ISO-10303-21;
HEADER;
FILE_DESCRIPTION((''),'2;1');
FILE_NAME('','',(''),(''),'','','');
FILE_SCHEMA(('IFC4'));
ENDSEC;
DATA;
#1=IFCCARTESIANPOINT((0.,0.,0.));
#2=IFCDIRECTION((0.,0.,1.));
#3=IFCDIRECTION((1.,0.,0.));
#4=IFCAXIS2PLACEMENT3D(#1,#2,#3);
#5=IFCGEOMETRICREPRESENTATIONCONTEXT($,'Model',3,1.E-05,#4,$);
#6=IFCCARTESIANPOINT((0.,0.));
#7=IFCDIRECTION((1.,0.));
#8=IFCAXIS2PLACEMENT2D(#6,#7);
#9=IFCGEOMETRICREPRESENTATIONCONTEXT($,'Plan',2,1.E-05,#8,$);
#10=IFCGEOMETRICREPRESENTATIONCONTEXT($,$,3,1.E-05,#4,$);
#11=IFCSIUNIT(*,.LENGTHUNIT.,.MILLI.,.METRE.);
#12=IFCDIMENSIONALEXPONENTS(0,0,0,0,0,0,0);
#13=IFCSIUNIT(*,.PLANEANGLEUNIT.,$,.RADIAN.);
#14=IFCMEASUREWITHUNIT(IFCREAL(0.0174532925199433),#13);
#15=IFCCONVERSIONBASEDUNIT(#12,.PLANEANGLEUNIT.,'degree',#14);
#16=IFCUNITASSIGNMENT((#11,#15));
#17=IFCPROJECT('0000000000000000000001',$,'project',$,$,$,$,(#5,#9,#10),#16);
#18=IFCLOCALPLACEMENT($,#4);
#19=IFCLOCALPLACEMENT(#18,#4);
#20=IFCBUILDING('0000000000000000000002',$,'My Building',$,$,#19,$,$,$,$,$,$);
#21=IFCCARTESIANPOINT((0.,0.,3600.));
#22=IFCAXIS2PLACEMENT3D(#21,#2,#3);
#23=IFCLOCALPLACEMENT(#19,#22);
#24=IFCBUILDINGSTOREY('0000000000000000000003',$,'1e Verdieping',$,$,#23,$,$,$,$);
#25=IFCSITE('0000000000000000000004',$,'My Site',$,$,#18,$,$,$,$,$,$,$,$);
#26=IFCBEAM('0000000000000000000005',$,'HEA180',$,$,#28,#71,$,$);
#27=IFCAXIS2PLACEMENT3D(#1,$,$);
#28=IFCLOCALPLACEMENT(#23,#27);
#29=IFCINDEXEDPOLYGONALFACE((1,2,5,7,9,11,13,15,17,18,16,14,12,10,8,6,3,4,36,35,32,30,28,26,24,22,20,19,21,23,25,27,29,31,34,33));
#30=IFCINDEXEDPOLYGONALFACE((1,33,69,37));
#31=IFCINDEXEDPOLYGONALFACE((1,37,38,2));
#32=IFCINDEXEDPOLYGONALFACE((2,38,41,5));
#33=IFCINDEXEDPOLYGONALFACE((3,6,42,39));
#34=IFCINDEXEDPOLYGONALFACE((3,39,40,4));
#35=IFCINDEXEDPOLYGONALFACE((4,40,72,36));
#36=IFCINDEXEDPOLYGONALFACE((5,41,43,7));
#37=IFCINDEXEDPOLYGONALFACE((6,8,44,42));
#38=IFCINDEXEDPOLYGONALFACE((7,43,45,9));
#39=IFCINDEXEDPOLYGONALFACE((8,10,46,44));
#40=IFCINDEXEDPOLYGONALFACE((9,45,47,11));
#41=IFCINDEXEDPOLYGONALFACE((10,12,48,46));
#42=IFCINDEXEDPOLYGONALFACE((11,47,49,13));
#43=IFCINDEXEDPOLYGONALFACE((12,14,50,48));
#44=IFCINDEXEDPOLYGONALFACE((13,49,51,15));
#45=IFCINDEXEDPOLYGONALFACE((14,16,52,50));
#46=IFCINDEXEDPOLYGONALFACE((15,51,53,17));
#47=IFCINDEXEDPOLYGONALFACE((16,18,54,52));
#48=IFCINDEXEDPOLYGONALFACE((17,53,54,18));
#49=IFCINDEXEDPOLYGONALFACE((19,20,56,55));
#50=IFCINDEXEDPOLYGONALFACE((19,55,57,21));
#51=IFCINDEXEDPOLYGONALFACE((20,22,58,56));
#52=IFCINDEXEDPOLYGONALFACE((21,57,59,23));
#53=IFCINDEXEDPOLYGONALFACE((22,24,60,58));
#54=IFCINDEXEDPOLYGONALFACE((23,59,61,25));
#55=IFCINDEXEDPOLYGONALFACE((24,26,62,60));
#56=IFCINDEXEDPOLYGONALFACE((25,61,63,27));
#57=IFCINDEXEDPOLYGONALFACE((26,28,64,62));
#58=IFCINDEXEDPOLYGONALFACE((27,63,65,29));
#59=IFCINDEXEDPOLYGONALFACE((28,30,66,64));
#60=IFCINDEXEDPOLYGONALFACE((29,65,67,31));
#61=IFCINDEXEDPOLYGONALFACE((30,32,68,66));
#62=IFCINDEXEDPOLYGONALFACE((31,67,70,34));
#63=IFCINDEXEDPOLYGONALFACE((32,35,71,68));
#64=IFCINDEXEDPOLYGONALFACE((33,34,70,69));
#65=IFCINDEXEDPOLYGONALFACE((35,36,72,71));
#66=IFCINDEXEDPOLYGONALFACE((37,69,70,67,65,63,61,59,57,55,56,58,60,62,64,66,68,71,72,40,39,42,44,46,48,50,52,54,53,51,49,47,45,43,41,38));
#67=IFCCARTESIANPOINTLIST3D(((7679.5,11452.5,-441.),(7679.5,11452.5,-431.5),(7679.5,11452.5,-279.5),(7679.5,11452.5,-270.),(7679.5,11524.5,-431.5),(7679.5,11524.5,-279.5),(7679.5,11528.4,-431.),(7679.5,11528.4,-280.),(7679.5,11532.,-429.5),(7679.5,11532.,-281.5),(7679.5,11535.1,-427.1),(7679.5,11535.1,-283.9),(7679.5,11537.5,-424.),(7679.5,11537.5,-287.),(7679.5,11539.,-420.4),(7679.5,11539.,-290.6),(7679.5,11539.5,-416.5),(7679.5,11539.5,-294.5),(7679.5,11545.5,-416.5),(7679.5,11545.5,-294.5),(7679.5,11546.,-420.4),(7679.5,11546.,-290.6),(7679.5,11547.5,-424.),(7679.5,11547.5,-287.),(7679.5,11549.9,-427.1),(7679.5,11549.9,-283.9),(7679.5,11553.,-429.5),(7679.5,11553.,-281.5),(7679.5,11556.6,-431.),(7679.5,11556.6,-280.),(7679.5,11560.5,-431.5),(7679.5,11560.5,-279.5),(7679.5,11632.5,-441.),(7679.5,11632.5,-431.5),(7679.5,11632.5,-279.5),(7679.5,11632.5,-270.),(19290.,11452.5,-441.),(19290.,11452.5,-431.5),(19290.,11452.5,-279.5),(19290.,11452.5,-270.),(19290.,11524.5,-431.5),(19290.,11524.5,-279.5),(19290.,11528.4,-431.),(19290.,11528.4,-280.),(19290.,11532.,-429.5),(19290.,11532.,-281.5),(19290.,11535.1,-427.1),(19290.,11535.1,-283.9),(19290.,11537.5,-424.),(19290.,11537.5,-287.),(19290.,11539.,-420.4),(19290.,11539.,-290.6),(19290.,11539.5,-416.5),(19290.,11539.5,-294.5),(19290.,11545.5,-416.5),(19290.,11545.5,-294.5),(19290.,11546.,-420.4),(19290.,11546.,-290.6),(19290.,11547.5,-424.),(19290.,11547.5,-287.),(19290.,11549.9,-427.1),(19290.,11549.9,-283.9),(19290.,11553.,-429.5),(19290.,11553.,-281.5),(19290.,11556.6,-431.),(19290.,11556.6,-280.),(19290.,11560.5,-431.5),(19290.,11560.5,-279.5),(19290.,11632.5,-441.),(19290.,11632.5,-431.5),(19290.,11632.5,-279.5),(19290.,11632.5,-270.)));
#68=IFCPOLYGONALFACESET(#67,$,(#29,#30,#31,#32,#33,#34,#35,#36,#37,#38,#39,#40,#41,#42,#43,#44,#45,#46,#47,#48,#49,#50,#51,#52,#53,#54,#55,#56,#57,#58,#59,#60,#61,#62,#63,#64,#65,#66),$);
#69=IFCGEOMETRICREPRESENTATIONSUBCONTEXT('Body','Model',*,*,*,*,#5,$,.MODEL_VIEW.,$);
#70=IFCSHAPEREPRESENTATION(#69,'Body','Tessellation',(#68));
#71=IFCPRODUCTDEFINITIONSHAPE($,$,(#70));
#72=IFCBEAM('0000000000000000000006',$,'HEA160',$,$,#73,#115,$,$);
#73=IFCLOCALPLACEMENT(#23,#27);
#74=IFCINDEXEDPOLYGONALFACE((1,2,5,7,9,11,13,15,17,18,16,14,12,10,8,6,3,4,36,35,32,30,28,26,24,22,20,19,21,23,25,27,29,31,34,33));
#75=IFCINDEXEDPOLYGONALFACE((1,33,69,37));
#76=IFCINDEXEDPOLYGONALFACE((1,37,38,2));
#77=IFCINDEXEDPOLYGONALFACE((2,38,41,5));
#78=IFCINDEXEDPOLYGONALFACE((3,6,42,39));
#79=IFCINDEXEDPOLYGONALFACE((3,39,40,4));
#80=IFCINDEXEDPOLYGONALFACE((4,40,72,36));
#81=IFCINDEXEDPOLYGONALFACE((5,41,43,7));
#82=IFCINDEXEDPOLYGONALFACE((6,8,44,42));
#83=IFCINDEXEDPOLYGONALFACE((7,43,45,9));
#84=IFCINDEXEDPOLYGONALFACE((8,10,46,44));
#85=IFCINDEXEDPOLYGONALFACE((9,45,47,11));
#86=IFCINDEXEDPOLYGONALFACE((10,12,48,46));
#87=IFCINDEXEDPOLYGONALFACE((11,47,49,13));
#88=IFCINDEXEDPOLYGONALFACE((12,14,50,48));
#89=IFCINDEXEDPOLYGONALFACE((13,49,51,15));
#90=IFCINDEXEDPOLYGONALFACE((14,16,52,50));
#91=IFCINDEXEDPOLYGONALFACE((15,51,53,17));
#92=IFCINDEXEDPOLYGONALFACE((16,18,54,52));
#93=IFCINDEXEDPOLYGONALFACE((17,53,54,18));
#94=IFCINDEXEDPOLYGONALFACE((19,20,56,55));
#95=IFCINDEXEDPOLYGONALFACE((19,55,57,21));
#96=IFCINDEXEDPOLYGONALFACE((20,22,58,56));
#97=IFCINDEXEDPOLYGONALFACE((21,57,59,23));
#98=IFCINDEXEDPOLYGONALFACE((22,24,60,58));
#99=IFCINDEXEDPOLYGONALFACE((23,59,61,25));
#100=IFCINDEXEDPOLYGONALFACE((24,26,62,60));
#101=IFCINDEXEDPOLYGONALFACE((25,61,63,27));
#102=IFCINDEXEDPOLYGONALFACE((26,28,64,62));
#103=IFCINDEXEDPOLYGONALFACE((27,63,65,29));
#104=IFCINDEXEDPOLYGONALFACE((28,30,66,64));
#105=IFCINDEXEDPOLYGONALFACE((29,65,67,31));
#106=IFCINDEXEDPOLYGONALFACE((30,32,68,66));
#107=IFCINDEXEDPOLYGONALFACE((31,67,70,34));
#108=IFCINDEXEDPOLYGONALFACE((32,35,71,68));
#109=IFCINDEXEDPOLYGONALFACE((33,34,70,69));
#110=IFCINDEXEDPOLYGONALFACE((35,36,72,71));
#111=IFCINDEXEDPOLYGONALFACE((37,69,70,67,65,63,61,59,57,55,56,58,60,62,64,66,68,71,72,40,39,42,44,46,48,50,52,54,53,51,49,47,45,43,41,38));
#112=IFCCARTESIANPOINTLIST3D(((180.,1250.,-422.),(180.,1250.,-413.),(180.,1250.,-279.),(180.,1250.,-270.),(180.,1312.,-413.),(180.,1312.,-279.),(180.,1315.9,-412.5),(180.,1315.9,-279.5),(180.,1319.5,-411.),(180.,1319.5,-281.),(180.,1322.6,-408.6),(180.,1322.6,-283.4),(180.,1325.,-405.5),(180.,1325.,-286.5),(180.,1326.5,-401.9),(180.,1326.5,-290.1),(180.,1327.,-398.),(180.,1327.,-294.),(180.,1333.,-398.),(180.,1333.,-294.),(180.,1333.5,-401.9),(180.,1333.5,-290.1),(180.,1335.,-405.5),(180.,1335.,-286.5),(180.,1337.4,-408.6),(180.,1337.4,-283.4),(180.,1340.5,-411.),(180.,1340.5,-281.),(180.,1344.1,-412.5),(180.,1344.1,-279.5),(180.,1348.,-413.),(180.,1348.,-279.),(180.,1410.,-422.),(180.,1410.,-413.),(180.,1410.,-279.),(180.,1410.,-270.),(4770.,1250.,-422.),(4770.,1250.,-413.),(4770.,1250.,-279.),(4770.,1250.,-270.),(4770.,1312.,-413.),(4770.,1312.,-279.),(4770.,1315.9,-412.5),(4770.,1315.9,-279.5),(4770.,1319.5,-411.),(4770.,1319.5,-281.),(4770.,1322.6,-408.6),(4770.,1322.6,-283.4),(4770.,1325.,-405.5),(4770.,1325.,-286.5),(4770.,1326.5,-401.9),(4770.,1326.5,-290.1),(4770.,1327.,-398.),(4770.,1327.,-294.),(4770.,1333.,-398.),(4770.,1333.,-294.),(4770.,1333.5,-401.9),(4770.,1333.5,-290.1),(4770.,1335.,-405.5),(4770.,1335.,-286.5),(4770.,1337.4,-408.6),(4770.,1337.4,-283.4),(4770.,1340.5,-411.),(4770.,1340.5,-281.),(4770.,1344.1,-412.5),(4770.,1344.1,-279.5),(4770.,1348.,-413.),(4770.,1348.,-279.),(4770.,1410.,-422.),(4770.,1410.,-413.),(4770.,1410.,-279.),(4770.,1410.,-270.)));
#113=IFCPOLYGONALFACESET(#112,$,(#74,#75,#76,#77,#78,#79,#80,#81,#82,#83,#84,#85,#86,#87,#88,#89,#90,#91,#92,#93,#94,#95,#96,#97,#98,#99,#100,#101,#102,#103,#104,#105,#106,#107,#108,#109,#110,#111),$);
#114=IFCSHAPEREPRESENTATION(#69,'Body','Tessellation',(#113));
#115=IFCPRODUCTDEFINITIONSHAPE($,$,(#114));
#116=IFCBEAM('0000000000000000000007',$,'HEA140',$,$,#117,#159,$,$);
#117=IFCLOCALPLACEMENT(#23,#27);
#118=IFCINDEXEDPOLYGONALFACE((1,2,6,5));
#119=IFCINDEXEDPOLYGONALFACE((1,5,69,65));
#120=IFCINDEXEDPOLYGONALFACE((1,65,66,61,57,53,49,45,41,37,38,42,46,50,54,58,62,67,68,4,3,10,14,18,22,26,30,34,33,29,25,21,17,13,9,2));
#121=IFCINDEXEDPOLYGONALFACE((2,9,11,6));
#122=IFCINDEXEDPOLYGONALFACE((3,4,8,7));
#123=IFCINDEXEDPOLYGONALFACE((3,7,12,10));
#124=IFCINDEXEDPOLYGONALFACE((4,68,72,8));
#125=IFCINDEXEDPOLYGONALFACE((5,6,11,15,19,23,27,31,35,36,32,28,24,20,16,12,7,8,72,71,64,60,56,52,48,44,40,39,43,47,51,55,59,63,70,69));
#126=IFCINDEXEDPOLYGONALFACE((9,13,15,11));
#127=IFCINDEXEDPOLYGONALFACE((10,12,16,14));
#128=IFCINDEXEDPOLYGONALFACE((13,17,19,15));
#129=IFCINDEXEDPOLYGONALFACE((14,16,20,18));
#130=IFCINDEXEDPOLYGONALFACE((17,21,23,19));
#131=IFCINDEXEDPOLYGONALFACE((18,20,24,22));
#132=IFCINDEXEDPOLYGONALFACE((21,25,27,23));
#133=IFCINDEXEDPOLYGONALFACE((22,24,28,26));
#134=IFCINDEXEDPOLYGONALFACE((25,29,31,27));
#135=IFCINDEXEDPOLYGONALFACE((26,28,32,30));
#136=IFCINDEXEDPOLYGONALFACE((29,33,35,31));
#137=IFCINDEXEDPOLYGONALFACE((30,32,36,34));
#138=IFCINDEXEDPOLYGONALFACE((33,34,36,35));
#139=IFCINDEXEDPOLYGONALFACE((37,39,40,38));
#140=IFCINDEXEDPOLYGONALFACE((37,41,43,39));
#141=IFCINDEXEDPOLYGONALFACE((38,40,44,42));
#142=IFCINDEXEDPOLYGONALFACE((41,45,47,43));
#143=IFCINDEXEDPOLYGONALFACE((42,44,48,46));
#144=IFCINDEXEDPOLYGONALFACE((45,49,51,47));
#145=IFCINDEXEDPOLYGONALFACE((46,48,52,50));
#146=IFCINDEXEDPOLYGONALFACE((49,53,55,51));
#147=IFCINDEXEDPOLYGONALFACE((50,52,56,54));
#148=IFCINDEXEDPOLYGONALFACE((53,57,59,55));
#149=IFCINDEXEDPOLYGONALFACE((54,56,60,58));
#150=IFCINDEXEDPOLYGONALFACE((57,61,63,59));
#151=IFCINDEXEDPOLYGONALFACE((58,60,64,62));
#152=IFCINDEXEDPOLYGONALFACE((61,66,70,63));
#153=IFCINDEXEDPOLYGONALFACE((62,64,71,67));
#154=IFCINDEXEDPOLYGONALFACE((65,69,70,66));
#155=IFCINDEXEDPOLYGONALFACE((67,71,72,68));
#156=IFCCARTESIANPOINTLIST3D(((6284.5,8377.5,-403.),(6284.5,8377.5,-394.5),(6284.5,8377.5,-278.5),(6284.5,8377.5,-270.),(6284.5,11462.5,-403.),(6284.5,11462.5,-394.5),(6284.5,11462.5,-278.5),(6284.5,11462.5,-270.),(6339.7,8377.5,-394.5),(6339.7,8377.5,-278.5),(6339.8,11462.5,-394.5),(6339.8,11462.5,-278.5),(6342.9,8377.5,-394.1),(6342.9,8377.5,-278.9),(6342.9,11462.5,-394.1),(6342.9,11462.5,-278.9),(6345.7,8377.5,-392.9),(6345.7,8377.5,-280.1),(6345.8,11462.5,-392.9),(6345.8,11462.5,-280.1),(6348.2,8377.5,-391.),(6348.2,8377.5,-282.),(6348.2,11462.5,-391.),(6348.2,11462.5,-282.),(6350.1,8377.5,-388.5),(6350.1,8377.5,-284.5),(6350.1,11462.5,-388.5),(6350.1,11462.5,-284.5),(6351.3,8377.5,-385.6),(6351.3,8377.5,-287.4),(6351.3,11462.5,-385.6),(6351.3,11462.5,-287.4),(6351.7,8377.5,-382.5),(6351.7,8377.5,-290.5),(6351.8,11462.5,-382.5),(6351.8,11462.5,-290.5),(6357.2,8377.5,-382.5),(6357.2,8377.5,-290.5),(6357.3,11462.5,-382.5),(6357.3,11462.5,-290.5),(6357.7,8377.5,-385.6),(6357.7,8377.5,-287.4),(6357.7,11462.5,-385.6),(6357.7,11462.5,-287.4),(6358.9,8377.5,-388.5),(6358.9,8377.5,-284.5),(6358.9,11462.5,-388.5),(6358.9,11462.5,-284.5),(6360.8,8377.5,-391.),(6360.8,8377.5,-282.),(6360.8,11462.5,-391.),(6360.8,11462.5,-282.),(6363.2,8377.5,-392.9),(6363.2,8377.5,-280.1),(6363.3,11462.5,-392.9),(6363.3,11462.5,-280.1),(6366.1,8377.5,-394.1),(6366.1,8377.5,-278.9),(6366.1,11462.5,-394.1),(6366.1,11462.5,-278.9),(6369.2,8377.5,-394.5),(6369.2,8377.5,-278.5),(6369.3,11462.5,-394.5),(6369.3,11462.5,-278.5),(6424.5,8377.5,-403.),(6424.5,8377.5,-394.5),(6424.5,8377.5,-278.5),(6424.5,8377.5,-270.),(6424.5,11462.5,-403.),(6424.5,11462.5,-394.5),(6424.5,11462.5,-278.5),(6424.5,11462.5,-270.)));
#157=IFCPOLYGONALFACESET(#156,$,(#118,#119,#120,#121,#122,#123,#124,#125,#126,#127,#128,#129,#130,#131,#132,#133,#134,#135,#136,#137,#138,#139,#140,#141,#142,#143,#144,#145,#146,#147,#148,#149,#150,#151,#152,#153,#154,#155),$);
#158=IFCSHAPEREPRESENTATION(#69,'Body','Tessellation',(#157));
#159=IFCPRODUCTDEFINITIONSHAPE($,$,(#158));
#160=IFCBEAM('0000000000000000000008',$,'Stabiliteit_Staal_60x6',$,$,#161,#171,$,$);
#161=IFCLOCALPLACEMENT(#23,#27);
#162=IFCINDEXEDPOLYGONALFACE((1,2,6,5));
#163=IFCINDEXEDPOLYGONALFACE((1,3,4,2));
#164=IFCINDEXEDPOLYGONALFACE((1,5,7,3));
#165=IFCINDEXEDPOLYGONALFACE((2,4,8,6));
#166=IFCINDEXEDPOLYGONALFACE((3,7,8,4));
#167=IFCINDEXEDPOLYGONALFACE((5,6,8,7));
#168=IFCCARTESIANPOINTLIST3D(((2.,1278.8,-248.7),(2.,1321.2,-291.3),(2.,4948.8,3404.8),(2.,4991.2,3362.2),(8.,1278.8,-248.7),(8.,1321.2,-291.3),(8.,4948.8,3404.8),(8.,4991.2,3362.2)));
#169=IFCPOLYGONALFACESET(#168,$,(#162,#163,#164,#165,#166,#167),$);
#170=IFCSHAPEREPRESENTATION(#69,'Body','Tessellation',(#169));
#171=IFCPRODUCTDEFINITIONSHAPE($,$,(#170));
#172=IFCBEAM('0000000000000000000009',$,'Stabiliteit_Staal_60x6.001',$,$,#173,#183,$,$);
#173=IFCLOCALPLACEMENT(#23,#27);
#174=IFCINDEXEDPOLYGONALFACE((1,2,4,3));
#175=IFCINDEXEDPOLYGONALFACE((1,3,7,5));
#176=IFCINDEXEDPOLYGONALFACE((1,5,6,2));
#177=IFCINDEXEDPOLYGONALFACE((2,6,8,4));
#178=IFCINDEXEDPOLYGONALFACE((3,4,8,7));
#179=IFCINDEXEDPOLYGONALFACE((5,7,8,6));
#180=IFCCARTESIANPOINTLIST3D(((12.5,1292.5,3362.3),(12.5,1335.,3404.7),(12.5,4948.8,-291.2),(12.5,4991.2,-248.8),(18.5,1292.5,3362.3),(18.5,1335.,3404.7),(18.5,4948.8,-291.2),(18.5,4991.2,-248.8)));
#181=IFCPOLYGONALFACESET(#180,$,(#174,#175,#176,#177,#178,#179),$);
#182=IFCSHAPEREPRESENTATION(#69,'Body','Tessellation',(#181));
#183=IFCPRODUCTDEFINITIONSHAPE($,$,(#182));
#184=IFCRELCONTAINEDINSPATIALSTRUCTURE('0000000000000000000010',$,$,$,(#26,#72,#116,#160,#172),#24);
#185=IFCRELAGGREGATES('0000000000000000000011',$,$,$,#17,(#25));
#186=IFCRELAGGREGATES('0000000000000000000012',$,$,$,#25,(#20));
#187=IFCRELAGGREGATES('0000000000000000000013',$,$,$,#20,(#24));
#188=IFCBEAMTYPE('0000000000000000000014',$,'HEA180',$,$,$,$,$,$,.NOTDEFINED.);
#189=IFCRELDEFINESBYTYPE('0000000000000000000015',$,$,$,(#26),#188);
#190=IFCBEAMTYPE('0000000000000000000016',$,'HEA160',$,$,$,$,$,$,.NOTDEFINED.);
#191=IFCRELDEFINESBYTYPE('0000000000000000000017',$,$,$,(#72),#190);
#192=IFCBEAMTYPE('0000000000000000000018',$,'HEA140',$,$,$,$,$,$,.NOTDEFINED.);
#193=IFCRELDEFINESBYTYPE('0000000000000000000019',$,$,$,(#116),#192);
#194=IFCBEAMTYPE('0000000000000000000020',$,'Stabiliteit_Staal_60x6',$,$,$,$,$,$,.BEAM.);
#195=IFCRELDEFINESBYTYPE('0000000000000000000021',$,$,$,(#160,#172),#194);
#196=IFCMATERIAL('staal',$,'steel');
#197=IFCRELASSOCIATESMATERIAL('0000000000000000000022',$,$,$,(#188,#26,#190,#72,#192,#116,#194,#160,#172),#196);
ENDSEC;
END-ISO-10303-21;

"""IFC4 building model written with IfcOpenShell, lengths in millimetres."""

from ifc_helpers import new_model, entity, si_unit, converted_unit, frame, origin_with_axes, origin_2d_with_axis, place, context, subcontext, project, spatial, rectangle, i_section, extrude, material, material_profile, profile_set, profile_usage, type_object, element, save


model = new_model("IFC4")

# Units and contexts
model_context = context("Model", 3, precision=1e-05, world=origin_with_axes())
plan_context = context("Plan", 2, precision=1e-05, world=origin_2d_with_axis())
context_of_model = context(None, 3, precision=1e-05, world=origin_with_axes())
body_context = subcontext(model_context, "Body", "Model", "MODEL_VIEW")
ifc_project = project(units=[si_unit("LENGTHUNIT", "METRE", prefix="MILLI"), converted_unit("PLANEANGLEUNIT", "degree", entity("IfcReal", 0.0174532925199433), si_unit("PLANEANGLEUNIT", "RADIAN"), dimensions=[0, 0, 0, 0, 0, 0, 0])], contexts=[model_context, plan_context, context_of_model])

# Site, building, storey
site_placement = place(None, origin_with_axes())
site = spatial("IfcSite", under=ifc_project, at=site_placement, Name="My Site")
building_placement = place(site_placement, origin_with_axes())
building = spatial("IfcBuilding", under=site, at=building_placement, Name="My Building")
storey_placement = place(building_placement, frame((0.0, 0.0, 3600.0), z_axis=(0.0, 0.0, 1.0), x_axis=(1.0, 0.0, 0.0)))
storey = spatial("IfcBuildingStorey", under=building, at=storey_placement, Name="1e Verdieping")

# Shared definitions
ifc_material = material(Name="staal", Category="steel")

# Beams
ifc_material_profile_1 = material_profile(ifc_material, i_section(OverallWidth=180.0, OverallDepth=171.0, WebThickness=6.0, FlangeThickness=9.5, FilletRadius=15.0))
ifc_profile_set_1 = profile_set([ifc_material_profile_1], Name="HEA180")
beam_type_1 = type_object("IfcBeamType", Name="HEA180", PredefinedType="NOTDEFINED", material=ifc_profile_set_1)
ifc_profile_usage_1 = profile_usage(ifc_profile_set_1)
beam_1_placement = place(storey_placement, frame((7679.5, 11542.5, -355.5), z_axis=(1.0, 0.0, 0.0), x_axis=(0.0, 1.0, 0.0)))
element("IfcBeam", 1, at=beam_1_placement, inside=storey, type_object=beam_type_1, material=ifc_profile_usage_1, Name="HEA180", context=body_context, shape_type="SweptSolid", body=[
    extrude(i_section(OverallWidth=180.0, OverallDepth=171.0, WebThickness=6.0, FlangeThickness=9.5, FilletRadius=15.0), origin_with_axes(), (0.0, 0.0, 1.0), 11610.5),
])
ifc_material_profile_2 = material_profile(ifc_material, i_section(OverallWidth=160.0, OverallDepth=152.0, WebThickness=6.0, FlangeThickness=9.0, FilletRadius=15.0))
ifc_profile_set_2 = profile_set([ifc_material_profile_2], Name="HEA160")
ifc_profile_usage_2 = profile_usage(ifc_profile_set_2, cardinal=5)
beam_type_2 = type_object("IfcBeamType", Name="HEA160", PredefinedType="NOTDEFINED", material=ifc_profile_set_2)
beam_2_placement = place(storey_placement, frame((180.0, 1330.0, -346.0), z_axis=(1.0, 0.0, 0.0), x_axis=(0.0, 1.0, 0.0)))
element("IfcBeam", 2, at=beam_2_placement, inside=storey, type_object=beam_type_2, material=ifc_profile_usage_2, Name="HEA160", context=body_context, shape_type="SweptSolid", body=[
    extrude(i_section(OverallWidth=160.0, OverallDepth=152.0, WebThickness=6.0, FlangeThickness=9.0, FilletRadius=15.0), origin_with_axes(), (0.0, 0.0, 1.0), 4590.0),
])
ifc_material_profile_3 = material_profile(ifc_material, i_section(OverallWidth=140.0, OverallDepth=133.0, WebThickness=5.5, FlangeThickness=8.5, FilletRadius=12.0))
ifc_profile_set_3 = profile_set([ifc_material_profile_3], Name="HEA140")
ifc_profile_usage_3 = profile_usage(ifc_profile_set_3)
beam_type_3 = type_object("IfcBeamType", Name="HEA140", PredefinedType="NOTDEFINED", material=ifc_profile_set_3)
beam_3_placement = place(storey_placement, frame((6354.5, 8377.5, -336.5), z_axis=(0.0, 1.0, 0.0), x_axis=(-1.0, 0.0, 0.0)))
element("IfcBeam", 3, at=beam_3_placement, inside=storey, type_object=beam_type_3, material=ifc_profile_usage_3, Name="HEA140", context=body_context, shape_type="SweptSolid", body=[
    extrude(i_section(OverallWidth=140.0, OverallDepth=133.0, WebThickness=5.5, FlangeThickness=8.5, FilletRadius=12.0), origin_with_axes(), (0.0, 0.0, 1.0), 3085.0),
])
ifc_material_profile_4 = material_profile(ifc_material, rectangle(XDim=6.0, YDim=60.0, kind="CURVE"))
ifc_profile_set_4 = profile_set([ifc_material_profile_4])
ifc_profile_usage_4 = profile_usage(ifc_profile_set_4)
beam_type_4 = type_object("IfcBeamType", Name="Stabiliteit_Staal_60x6", PredefinedType="BEAM", material=ifc_profile_set_4)
beam_4_placement = place(storey_placement, frame((5.0, 1300.0, -270.0), z_axis=(0.0, 0.708698, 0.705512), x_axis=(-1.0, 0.0, 0.0)))
element("IfcBeam", 4, at=beam_4_placement, inside=storey, type_object=beam_type_4, material=ifc_profile_usage_4, Name="Stabiliteit_Staal_60x6", context=body_context, shape_type="SweptSolid", body=[
    extrude(rectangle(XDim=6.0, YDim=60.0, kind="CURVE"), origin_with_axes(), (0.0, 0.0, 1.0), 5178.5),
])
ifc_profile_usage_5 = profile_usage(ifc_profile_set_4)
beam_5_placement = place(storey_placement, frame((15.5, 4970.0, -270.0), z_axis=(0.0, -0.707374, 0.70684), x_axis=(1.0, 0.0, 0.0)))
element("IfcBeam", 5, at=beam_5_placement, inside=storey, type_object=beam_type_4, material=ifc_profile_usage_5, Name="Stabiliteit_Staal_60x6.001", context=body_context, shape_type="SweptSolid", body=[
    extrude(rectangle(XDim=6.0, YDim=60.0, kind="CURVE"), origin_with_axes(), (0.0, 0.0, 1.0), 5168.8),
])

save(model, "model.ifc")
